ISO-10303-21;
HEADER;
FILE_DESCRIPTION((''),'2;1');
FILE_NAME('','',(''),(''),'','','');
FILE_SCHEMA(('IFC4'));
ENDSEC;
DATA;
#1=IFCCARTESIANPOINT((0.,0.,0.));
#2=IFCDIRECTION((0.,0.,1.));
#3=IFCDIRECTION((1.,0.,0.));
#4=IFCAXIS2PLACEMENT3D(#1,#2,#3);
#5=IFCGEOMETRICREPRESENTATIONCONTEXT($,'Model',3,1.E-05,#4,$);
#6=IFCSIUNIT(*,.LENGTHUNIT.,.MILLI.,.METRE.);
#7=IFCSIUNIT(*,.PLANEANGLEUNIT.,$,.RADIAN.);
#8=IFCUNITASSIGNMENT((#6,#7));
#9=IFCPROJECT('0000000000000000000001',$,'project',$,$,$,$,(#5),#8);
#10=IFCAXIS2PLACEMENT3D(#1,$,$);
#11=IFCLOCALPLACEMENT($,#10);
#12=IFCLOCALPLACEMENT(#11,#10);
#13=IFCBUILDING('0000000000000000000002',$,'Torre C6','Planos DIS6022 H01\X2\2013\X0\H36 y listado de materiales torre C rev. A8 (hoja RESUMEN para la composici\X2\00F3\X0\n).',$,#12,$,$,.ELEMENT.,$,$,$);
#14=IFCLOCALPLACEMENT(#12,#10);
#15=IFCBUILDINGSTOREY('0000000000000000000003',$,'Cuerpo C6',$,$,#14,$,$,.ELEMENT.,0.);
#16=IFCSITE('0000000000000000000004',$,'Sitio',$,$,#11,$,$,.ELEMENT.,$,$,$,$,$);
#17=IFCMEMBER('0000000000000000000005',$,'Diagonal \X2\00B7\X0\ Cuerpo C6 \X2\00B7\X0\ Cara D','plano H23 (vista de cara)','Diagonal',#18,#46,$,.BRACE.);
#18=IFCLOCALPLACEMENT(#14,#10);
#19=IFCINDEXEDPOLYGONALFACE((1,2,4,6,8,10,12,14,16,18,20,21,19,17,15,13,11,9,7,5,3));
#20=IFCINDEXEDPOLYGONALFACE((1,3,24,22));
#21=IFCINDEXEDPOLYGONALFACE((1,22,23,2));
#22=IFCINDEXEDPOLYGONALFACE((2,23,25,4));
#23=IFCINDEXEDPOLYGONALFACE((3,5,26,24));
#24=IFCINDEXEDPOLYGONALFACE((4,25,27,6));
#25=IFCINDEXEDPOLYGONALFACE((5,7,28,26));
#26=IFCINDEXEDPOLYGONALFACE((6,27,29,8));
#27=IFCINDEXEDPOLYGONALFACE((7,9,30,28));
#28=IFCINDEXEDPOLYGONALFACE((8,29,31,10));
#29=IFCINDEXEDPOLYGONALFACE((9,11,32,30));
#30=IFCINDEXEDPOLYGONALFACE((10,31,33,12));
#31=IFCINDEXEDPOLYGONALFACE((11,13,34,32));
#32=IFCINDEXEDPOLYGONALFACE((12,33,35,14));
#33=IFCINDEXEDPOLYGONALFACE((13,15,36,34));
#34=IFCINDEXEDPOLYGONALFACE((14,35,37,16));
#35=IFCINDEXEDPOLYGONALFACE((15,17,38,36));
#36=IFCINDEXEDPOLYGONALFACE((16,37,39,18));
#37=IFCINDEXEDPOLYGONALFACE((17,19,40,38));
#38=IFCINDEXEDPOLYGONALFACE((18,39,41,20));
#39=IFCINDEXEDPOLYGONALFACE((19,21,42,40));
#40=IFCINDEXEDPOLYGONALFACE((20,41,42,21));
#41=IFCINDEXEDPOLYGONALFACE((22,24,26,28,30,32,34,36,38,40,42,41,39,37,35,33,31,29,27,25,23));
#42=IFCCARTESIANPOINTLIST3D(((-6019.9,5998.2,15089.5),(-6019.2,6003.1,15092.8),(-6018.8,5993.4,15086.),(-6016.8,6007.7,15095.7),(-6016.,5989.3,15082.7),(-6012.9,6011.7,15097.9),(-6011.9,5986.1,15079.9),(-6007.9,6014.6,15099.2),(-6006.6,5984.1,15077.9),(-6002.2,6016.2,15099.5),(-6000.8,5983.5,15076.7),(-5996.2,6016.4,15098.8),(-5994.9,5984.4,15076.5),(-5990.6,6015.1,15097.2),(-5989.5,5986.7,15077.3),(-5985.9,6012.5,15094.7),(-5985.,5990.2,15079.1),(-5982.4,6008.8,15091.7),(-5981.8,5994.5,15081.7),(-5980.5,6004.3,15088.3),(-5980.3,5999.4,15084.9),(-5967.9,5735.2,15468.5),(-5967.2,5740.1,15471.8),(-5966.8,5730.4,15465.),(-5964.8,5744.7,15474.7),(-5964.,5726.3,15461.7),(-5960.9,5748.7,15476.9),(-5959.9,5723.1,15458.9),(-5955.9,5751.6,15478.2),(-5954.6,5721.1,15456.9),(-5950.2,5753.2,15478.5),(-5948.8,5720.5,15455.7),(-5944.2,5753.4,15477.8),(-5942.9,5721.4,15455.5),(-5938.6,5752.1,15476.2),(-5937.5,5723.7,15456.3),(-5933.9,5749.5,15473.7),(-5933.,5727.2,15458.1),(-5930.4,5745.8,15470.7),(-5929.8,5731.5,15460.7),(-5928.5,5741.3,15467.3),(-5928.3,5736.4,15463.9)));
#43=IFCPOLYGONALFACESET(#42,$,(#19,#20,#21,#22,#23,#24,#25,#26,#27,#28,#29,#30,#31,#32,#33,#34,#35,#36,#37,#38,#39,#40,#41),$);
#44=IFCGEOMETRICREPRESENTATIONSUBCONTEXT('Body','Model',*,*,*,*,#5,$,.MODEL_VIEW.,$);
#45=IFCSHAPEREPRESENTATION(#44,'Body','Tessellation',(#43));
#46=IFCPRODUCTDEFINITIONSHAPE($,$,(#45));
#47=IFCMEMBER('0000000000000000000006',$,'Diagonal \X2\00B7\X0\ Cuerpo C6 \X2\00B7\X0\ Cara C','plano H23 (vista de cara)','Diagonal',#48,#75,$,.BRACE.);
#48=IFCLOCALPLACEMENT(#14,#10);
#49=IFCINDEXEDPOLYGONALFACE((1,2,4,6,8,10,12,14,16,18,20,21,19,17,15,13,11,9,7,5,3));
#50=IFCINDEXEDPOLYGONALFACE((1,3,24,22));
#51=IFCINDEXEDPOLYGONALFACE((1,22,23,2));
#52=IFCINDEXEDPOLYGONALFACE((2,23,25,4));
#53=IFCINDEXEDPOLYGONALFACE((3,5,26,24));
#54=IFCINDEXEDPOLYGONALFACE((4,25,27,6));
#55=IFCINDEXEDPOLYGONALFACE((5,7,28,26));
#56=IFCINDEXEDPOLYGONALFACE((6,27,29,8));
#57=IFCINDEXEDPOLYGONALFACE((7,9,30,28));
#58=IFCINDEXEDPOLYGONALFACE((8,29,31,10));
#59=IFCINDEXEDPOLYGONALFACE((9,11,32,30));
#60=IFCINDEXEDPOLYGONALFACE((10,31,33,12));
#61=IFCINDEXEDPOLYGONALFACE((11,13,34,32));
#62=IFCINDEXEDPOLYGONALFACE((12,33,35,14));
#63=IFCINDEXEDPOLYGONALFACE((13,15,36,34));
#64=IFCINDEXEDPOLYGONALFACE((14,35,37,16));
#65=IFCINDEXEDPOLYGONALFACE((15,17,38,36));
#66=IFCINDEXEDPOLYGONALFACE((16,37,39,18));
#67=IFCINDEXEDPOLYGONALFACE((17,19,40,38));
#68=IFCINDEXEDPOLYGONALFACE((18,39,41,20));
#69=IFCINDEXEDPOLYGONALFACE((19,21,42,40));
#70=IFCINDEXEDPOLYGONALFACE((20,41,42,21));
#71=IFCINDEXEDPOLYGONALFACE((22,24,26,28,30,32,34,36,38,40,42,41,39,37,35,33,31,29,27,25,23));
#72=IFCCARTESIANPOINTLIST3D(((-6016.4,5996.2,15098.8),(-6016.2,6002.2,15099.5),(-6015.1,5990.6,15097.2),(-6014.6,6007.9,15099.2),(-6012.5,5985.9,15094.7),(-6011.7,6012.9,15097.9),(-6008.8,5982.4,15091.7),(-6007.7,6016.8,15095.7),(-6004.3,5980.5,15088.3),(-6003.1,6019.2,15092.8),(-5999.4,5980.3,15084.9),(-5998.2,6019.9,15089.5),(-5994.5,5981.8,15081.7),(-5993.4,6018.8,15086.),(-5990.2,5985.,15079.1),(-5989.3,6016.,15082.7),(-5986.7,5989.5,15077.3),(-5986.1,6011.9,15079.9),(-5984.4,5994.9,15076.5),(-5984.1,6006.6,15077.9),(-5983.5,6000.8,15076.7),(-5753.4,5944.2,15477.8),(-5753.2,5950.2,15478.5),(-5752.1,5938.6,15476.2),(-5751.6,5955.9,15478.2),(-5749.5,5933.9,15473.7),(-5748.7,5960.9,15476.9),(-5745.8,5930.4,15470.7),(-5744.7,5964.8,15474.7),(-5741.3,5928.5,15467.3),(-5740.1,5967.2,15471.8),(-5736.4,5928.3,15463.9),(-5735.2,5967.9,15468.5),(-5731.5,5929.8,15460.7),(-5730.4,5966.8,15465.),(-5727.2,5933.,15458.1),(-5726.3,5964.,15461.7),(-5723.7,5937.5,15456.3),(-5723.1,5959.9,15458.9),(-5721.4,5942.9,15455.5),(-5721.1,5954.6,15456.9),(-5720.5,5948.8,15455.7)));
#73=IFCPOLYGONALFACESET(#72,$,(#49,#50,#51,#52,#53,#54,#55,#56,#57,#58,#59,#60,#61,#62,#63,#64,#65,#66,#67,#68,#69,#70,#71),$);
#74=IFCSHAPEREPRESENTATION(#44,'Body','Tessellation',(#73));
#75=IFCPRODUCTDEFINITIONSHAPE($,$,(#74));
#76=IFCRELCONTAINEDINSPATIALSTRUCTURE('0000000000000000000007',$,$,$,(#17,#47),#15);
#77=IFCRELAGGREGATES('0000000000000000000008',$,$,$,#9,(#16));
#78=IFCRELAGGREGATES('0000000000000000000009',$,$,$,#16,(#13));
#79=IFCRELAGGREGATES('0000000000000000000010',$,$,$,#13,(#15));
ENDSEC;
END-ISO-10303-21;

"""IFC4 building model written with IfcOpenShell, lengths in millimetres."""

from ifc_helpers import new_model, si_unit, frame, origin, origin_with_axes, place, context, subcontext, project, spatial, circle, extrude, element, save


model = new_model("IFC4")

# Units and contexts
model_context = context("Model", 3, precision=1e-05, world=origin_with_axes())
body_context = subcontext(model_context, "Body", "Model", "MODEL_VIEW")
ifc_project = project(units=[si_unit("LENGTHUNIT", "METRE", prefix="MILLI"), si_unit("PLANEANGLEUNIT", "RADIAN")], contexts=[model_context])

# Site, building, storey
site_placement = place(None, origin())
site = spatial("IfcSite", under=ifc_project, at=site_placement, Name="Sitio", CompositionType="ELEMENT")
building_placement = place(site_placement, origin())
building = spatial("IfcBuilding", under=site, at=building_placement, Name="Torre C6", Description="Planos DIS6022 H01–H36 y listado de materiales torre C rev. A8 (hoja RESUMEN para la composición).", CompositionType="ELEMENT")
storey_placement = place(building_placement, origin())
storey = spatial("IfcBuildingStorey", under=building, at=storey_placement, Name="Cuerpo C6", CompositionType="ELEMENT", Elevation=0.0)

# Members
for number, where, z_axis, x_axis, name in (
    (1, (-5948.0, 5737.0, 15467.0), (-0.112012, 0.566524, -0.816397), (0.750848, -0.489898, -0.442975), "Diagonal · Cuerpo C6 · Cara D"),
    (2, (-5737.0, 5948.0, 15467.0), (-0.566524, 0.112012, -0.816397), (0.489898, -0.750848, -0.442975), "Diagonal · Cuerpo C6 · Cara C"),
):
    element("IfcMember", number, at=place(storey_placement, frame(where, z_axis=z_axis, x_axis=x_axis)), inside=storey, Name=name, Description="plano H23 (vista de cara)", ObjectType="Diagonal", PredefinedType="BRACE", context=body_context, shape_type="SweptSolid", body=[
        extrude(circle(Radius=20.0), None, (0.0, 0.0, 1.0), 464.2),
    ])

save(model, "model.ifc")
